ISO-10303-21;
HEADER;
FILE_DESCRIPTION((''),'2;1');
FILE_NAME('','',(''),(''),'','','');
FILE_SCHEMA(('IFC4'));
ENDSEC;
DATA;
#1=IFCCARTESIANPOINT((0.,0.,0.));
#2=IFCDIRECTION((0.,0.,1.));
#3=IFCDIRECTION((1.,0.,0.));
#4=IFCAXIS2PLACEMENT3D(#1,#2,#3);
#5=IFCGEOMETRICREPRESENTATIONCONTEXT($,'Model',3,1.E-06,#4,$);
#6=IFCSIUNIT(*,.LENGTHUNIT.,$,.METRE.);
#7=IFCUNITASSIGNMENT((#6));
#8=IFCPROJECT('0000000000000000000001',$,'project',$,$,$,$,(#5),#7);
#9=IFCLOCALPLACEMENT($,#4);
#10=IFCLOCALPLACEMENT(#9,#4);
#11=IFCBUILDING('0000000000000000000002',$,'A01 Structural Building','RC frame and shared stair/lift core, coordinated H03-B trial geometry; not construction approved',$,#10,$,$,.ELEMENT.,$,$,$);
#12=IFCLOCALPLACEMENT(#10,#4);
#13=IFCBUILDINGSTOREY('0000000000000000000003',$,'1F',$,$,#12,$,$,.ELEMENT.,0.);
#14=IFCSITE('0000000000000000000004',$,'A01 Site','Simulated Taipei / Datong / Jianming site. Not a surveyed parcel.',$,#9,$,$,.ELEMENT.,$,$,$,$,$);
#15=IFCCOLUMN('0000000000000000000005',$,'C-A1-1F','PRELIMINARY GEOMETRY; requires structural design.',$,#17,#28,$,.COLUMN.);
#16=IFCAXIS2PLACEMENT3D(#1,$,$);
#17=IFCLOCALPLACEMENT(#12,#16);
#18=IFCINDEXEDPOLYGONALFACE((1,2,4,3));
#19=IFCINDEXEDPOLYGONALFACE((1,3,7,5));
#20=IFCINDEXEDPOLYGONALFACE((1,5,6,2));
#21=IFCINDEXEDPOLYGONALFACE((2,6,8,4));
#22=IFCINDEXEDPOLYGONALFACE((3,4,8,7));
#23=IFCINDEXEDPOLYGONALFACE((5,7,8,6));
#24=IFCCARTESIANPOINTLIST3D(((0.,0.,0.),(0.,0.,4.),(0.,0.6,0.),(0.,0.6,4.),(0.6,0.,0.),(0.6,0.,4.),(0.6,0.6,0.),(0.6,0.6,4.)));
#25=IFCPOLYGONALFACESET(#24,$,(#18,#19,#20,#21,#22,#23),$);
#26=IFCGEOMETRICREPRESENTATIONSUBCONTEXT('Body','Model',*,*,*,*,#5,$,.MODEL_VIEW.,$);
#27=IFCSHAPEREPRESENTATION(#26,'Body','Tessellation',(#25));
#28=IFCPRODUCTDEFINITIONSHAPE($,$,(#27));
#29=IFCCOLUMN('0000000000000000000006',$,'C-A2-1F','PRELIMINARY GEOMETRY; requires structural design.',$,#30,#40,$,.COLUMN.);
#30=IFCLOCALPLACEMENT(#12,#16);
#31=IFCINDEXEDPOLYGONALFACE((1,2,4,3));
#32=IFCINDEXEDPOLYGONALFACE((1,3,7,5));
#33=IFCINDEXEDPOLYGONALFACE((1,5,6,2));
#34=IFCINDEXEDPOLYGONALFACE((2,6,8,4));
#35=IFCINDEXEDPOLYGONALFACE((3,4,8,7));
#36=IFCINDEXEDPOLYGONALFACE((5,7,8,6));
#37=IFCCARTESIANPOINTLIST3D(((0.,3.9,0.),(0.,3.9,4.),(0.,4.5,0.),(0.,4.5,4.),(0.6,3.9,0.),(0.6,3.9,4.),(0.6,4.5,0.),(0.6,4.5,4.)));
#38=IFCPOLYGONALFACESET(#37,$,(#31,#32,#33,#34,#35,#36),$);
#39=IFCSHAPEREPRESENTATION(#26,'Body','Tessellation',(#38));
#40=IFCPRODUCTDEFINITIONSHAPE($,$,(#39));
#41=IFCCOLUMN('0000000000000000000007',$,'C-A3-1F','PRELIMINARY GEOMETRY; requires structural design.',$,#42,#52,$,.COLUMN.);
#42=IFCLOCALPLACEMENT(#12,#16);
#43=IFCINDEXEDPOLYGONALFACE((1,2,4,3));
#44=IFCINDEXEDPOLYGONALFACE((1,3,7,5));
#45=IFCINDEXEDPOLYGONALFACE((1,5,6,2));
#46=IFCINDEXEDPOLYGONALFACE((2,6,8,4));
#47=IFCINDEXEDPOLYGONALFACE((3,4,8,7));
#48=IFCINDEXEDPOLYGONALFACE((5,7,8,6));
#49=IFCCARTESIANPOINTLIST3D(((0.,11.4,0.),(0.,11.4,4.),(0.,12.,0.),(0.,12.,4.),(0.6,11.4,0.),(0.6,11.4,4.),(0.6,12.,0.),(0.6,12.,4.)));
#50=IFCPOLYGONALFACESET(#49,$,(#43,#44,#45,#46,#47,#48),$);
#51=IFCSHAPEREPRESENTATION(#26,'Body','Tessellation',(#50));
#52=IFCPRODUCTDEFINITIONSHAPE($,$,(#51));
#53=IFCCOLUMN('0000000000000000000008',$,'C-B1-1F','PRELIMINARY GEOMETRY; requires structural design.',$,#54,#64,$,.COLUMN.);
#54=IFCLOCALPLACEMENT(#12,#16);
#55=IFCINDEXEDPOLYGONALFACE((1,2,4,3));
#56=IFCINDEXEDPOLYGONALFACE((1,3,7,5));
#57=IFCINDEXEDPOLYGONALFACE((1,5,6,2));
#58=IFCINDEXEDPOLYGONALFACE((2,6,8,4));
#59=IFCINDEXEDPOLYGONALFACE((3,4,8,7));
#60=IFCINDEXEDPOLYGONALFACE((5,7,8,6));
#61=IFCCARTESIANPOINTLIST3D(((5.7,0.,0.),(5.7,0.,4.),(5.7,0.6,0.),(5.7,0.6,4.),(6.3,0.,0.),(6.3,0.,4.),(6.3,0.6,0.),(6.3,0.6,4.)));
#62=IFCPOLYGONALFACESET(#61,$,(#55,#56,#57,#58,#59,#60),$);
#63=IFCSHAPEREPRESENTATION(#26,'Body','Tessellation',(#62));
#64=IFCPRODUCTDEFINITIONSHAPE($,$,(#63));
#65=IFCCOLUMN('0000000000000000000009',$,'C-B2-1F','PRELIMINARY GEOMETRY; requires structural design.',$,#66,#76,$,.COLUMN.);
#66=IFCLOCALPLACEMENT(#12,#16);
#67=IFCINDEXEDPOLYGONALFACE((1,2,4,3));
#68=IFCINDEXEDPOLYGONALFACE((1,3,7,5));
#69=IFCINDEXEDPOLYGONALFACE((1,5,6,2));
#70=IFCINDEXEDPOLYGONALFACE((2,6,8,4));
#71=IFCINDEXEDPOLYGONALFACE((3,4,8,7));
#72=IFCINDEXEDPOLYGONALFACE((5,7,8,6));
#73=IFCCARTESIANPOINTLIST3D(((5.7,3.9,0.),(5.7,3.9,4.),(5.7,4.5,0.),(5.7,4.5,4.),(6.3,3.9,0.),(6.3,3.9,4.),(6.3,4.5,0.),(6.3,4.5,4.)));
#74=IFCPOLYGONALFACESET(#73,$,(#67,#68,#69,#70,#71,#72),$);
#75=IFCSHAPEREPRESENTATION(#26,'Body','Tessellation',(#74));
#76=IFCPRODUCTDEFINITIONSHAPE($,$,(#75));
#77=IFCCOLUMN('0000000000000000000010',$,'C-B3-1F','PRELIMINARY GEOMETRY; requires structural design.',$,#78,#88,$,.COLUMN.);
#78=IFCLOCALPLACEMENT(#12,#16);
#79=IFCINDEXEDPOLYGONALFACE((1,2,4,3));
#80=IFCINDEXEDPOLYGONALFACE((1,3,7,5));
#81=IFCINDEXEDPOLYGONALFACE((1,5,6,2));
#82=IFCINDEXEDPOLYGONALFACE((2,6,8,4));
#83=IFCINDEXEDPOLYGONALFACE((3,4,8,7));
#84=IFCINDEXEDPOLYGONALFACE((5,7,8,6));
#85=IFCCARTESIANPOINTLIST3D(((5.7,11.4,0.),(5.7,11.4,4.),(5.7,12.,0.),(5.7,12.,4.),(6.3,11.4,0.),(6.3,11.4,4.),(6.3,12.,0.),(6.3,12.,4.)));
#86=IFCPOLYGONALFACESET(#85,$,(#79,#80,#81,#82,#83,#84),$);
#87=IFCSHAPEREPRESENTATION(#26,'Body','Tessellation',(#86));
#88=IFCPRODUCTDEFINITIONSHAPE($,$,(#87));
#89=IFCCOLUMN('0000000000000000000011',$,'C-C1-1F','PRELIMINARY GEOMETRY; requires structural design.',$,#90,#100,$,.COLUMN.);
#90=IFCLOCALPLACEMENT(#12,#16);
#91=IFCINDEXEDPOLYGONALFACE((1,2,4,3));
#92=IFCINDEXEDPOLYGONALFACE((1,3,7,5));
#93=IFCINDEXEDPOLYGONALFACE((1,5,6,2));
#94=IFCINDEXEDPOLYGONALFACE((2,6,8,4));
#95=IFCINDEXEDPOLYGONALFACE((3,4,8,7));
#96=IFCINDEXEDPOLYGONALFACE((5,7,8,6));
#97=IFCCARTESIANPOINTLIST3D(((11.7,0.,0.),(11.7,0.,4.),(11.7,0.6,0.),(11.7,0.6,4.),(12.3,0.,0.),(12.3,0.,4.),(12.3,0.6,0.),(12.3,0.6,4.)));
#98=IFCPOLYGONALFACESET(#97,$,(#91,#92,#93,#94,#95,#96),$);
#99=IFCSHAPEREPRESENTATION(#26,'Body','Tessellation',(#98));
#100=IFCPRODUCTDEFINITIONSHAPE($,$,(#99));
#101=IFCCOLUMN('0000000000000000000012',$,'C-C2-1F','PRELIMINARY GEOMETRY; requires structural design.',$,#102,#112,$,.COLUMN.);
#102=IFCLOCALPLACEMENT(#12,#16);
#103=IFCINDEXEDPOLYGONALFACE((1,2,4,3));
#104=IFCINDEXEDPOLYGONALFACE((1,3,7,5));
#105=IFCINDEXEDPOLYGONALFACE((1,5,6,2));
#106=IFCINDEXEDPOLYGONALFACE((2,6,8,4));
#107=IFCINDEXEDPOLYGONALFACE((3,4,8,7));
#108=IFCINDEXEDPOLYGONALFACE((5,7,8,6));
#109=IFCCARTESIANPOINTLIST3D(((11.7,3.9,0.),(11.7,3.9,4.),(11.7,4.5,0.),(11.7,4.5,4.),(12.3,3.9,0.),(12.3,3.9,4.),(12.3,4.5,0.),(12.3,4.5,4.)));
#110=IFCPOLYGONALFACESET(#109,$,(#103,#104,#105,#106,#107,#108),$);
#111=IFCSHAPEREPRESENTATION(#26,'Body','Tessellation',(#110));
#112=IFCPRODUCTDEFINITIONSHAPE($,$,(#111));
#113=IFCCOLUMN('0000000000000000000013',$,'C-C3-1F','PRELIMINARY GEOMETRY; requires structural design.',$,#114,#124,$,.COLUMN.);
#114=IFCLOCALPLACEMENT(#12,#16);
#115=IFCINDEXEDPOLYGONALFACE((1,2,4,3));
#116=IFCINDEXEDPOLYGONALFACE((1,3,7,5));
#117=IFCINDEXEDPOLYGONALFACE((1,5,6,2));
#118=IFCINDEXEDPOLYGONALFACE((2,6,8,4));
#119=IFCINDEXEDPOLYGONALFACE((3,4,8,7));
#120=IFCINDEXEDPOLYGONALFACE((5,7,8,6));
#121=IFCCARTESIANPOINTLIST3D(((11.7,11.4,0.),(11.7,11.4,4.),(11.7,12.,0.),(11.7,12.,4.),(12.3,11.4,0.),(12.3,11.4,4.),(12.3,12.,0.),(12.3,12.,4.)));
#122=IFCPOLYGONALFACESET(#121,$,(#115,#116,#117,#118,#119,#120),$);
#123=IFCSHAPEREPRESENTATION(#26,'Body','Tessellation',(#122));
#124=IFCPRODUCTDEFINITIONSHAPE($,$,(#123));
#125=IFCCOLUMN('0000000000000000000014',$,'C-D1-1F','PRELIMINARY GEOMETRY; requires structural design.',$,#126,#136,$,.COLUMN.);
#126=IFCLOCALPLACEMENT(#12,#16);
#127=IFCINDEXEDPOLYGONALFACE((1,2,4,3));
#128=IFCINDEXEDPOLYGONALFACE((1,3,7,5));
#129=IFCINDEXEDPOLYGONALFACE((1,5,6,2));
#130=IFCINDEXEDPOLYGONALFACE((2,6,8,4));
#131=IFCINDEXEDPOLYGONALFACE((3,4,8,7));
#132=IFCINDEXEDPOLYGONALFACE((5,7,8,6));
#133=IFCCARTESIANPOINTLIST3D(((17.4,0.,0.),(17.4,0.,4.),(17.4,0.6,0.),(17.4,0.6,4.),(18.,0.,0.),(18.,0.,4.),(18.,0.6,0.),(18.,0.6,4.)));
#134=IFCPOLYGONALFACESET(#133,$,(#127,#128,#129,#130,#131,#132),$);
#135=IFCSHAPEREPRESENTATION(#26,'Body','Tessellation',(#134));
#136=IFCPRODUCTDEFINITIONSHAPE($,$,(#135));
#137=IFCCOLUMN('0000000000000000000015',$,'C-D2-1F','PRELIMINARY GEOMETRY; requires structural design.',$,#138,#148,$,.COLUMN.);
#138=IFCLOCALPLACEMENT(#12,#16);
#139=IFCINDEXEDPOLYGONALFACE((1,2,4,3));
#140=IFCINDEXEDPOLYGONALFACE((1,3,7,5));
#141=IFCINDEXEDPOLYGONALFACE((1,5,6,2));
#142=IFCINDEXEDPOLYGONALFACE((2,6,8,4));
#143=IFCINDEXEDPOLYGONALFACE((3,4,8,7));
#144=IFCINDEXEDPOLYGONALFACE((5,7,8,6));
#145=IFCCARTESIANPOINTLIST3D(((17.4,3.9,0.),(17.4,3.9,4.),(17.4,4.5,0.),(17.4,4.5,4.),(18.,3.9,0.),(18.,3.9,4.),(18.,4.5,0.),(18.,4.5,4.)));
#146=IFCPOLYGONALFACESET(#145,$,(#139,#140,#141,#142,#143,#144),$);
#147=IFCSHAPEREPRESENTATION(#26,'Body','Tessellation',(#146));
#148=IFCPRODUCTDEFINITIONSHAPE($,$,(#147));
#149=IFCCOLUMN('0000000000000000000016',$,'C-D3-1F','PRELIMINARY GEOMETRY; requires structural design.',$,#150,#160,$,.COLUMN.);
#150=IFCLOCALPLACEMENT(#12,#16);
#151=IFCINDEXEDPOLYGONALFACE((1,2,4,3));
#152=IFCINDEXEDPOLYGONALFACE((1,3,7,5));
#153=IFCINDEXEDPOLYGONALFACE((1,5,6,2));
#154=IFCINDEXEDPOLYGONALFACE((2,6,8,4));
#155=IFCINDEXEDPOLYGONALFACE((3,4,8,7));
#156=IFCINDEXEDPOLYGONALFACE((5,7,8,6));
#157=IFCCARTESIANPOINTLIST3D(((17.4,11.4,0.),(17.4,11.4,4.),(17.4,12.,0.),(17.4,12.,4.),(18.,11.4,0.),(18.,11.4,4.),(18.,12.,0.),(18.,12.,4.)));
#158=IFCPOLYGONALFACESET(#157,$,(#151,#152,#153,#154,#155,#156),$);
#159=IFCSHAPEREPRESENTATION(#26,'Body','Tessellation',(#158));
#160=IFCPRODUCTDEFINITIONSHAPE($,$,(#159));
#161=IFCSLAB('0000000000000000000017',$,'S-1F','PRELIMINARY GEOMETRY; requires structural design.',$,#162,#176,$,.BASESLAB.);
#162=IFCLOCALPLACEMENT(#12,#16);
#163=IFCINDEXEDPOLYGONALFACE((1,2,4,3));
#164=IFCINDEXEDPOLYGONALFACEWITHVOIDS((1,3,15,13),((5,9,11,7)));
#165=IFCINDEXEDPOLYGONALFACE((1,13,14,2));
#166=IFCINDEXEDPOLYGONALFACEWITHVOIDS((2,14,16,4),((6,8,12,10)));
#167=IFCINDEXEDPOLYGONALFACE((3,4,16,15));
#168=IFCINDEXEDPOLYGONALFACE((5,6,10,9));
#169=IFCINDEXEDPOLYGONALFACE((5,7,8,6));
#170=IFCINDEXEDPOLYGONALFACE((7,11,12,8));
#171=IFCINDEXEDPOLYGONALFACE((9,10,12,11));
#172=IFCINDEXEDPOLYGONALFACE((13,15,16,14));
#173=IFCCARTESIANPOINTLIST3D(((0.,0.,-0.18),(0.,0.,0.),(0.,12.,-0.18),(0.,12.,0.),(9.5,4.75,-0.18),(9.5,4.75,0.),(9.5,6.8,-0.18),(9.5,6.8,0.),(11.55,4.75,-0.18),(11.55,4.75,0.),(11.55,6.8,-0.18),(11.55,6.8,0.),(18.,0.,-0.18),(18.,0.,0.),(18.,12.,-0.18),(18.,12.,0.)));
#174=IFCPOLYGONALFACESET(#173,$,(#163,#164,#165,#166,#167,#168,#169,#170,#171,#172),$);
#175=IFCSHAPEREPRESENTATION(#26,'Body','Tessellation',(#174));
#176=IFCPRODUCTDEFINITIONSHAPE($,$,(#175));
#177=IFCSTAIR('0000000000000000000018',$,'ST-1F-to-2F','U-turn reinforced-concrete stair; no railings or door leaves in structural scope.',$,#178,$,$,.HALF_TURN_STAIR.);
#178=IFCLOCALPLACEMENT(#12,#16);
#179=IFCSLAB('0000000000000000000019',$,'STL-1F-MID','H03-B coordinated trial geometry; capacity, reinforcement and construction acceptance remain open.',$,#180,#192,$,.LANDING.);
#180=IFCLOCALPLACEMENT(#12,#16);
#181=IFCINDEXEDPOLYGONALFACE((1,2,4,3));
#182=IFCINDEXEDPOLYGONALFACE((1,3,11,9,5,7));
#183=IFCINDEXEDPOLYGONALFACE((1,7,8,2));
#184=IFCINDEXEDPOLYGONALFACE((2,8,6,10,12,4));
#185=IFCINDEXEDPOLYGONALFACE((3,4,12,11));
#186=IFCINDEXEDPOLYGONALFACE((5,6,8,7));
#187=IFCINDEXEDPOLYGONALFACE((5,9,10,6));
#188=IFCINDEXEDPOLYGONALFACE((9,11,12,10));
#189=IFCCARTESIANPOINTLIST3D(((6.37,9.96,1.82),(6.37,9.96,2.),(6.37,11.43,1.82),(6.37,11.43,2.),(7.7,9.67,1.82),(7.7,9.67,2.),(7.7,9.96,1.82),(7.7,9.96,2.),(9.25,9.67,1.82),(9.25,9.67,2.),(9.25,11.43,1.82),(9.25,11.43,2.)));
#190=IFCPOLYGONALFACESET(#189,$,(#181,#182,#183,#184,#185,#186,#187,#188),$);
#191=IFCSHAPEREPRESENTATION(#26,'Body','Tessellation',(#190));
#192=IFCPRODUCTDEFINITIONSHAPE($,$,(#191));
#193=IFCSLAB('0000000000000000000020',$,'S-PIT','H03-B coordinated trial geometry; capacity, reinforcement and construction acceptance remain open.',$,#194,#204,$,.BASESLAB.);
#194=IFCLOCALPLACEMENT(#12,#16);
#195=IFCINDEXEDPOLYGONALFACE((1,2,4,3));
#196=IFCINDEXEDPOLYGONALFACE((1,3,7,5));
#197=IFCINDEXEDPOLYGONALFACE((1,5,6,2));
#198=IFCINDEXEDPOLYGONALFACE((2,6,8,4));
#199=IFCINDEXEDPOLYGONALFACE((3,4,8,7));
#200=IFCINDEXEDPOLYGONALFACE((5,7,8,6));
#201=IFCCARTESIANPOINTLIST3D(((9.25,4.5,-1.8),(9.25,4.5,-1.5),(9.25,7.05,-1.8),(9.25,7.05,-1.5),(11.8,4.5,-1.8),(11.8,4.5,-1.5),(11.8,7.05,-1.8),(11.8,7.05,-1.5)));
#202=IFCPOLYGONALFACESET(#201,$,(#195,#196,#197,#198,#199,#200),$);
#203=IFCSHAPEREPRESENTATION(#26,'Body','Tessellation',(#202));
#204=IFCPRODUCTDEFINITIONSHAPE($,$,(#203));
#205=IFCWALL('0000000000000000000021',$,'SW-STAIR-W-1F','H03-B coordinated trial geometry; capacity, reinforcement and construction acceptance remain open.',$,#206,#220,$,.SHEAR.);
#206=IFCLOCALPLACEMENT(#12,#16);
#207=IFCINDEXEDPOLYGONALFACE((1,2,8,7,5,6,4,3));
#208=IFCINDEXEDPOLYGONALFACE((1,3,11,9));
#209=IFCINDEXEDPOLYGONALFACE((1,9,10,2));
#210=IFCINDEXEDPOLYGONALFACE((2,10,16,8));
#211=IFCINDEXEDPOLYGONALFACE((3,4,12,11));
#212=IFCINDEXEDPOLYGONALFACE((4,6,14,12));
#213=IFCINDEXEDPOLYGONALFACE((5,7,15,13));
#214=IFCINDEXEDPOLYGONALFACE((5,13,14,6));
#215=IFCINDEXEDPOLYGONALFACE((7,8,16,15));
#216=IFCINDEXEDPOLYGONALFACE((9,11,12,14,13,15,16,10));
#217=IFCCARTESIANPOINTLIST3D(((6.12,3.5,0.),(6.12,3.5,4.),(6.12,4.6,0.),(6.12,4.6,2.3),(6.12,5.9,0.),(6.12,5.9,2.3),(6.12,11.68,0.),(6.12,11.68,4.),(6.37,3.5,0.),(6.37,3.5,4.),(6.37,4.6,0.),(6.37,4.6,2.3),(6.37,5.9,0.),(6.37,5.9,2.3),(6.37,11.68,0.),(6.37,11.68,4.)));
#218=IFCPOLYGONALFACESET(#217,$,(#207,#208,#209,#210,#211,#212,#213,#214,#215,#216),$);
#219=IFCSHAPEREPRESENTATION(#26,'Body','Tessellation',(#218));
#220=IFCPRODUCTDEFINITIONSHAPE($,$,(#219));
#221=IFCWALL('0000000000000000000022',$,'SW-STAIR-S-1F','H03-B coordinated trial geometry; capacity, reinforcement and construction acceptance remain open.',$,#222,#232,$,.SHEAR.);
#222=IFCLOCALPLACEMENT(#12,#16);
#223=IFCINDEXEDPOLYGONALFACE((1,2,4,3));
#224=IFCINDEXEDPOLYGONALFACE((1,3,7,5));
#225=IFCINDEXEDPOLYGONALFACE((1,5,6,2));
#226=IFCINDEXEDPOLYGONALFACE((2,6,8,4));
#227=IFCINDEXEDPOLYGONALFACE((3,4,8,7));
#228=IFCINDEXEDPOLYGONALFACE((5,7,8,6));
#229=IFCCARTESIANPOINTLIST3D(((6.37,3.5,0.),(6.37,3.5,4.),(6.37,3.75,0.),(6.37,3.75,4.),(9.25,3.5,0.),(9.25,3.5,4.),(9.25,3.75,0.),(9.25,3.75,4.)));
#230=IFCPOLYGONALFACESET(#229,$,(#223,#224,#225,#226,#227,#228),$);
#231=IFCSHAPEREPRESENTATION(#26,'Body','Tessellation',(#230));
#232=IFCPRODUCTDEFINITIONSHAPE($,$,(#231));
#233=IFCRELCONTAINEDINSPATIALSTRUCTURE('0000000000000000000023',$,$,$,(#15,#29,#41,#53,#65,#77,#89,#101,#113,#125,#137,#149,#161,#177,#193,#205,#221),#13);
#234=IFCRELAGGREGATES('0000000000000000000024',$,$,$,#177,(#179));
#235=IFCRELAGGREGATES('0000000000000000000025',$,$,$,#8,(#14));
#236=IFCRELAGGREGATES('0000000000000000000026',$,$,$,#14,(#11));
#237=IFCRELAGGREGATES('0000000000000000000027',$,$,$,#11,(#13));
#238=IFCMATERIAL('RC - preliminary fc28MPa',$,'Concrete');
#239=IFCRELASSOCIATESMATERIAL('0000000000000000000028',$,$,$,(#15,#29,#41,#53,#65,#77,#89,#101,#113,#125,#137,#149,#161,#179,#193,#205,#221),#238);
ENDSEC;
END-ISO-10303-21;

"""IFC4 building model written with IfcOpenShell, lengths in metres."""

from ifc_helpers import new_model, si_unit, frame, origin_with_axes, place, context, subcontext, project, spatial, polyline, rectangle, outline, extrude, material, element, aggregate, save


model = new_model("IFC4")

# Units and contexts
model_context = context("Model", 3, precision=1e-06, world=origin_with_axes())
body_context = subcontext(model_context, "Body", "Model", "MODEL_VIEW")
ifc_project = project(units=[si_unit("LENGTHUNIT", "METRE")], contexts=[model_context])

# Site, building, storey
site_placement = place(None, origin_with_axes())
site = spatial("IfcSite", under=ifc_project, at=site_placement, Name="A01 Site", Description="Simulated Taipei / Datong / Jianming site. Not a surveyed parcel.", CompositionType="ELEMENT")
building_placement = place(site_placement, origin_with_axes())
building = spatial("IfcBuilding", under=site, at=building_placement, Name="A01 Structural Building", Description="RC frame and shared stair/lift core, coordinated H03-B trial geometry; not construction approved", CompositionType="ELEMENT")
storey_placement = place(building_placement, origin_with_axes())
storey = spatial("IfcBuildingStorey", under=building, at=storey_placement, Name="1F", CompositionType="ELEMENT", Elevation=0.0)

# Columns
ifc_material = material(Name="RC - preliminary fc28MPa", Category="Concrete")
for number, where, z_axis, x_axis, name in (
    (1, (0.3, 0.3, 0.0), (0.0, 0.0, 1.0), (1.0, 0.0, 0.0), "C-A1-1F"),
    (2, (0.3, 4.2, 0.0), (0.0, 0.0, 1.0), (1.0, 0.0, 0.0), "C-A2-1F"),
    (3, (0.3, 11.7, 0.0), (0.0, 0.0, 1.0), (1.0, 0.0, 0.0), "C-A3-1F"),
    (4, (6.0, 0.3, 0.0), (0.0, 0.0, 1.0), (1.0, 0.0, 0.0), "C-B1-1F"),
    (5, (6.0, 4.2, 0.0), (0.0, 0.0, 1.0), (1.0, 0.0, 0.0), "C-B2-1F"),
    (6, (6.0, 11.7, 0.0), (0.0, 0.0, 1.0), (1.0, 0.0, 0.0), "C-B3-1F"),
    (7, (12.0, 0.3, 0.0), (0.0, 0.0, 1.0), (1.0, 0.0, 0.0), "C-C1-1F"),
    (8, (12.0, 4.2, 0.0), (0.0, 0.0, 1.0), (1.0, 0.0, 0.0), "C-C2-1F"),
    (9, (12.0, 11.7, 0.0), (0.0, 0.0, 1.0), (1.0, 0.0, 0.0), "C-C3-1F"),
    (10, (17.7, 0.3, 0.0), (0.0, 0.0, 1.0), (1.0, 0.0, 0.0), "C-D1-1F"),
    (11, (17.7, 4.2, 0.0), (0.0, 0.0, 1.0), (1.0, 0.0, 0.0), "C-D2-1F"),
    (12, (17.7, 11.7, 0.0), (0.0, 0.0, 1.0), (1.0, 0.0, 0.0), "C-D3-1F"),
):
    element("IfcColumn", number, at=place(storey_placement, frame(where, z_axis=z_axis, x_axis=x_axis)), inside=storey, material=ifc_material, Name=name, Description="PRELIMINARY GEOMETRY; requires structural design.", PredefinedType="COLUMN", context=body_context, shape_type="SweptSolid", body=[
        extrude(rectangle(XDim=0.6, YDim=0.6), origin_with_axes(), (0.0, 0.0, 1.0), 4.0),
    ])

# Slab, opening
slab_1_placement = place(storey_placement, frame((9.0, 6.0, -0.18), z_axis=(0.0, 0.0, 1.0), x_axis=(1.0, 0.0, 0.0)))
slab_1 = element("IfcSlab", 13, at=slab_1_placement, inside=storey, material=ifc_material, Name="S-1F", Description="PRELIMINARY GEOMETRY; requires structural design.", PredefinedType="BASESLAB", context=body_context, shape_type="SweptSolid", body=[
    extrude(rectangle(XDim=18.0, YDim=12.0), origin_with_axes(), (0.0, 0.0, 1.0), 0.18),
])
opening_1_placement = place(storey_placement, frame((10.525, 5.775, -0.23), z_axis=(0.0, 0.0, 1.0), x_axis=(1.0, 0.0, 0.0)))
element("IfcOpeningElement", 14, at=opening_1_placement, cuts=slab_1, PredefinedType="OPENING", context=body_context, shape_type="SweptSolid", body=[
    extrude(rectangle(XDim=2.05, YDim=2.05), origin_with_axes(), (0.0, 0.0, 1.0), 0.28),
])

# Stair, slab
stair_placement = place(storey_placement, origin_with_axes())
stair = element("IfcStair", 15, at=stair_placement, inside=storey, Name="ST-1F-to-2F", Description="U-turn reinforced-concrete stair; no railings or door leaves in structural scope.", PredefinedType="HALF_TURN_STAIR")
placement = place(None, origin_with_axes())
slab_2 = element("IfcSlab", 16, at=placement, material=ifc_material, Name="STL-1F-MID", Description="H03-B coordinated trial geometry; capacity, reinforcement and construction acceptance remain open.", PredefinedType="LANDING", context=body_context, shape_type="SweptSolid", body=[
    extrude(outline(polyline([(6.37, 9.96), (7.7, 9.96), (7.7, 9.67), (9.25, 9.67), (9.25, 11.43), (6.37, 11.43), (6.37, 9.96)])), frame((0.0, 0.0, 1.82), z_axis=(0.0, 0.0, 1.0), x_axis=(1.0, 0.0, 0.0)), (0.0, 0.0, 1.0), 0.18),
])

# Slab
element("IfcSlab", 17, at=placement, inside=storey, material=ifc_material, Name="S-PIT", Description="H03-B coordinated trial geometry; capacity, reinforcement and construction acceptance remain open.", PredefinedType="BASESLAB", context=body_context, shape_type="SweptSolid", body=[
    extrude(outline(polyline([(11.8, 4.5), (11.8, 7.05), (9.25, 7.05), (9.25, 4.5), (11.8, 4.5)])), frame((0.0, 0.0, -1.8), z_axis=(0.0, 0.0, 1.0), x_axis=(1.0, 0.0, 0.0)), (0.0, 0.0, 1.0), 0.3),
])

# Wall, opening
wall_1 = element("IfcWall", 18, at=placement, inside=storey, material=ifc_material, Name="SW-STAIR-W-1F", Description="H03-B coordinated trial geometry; capacity, reinforcement and construction acceptance remain open.", PredefinedType="SHEAR", context=body_context, shape_type="SweptSolid", body=[
    extrude(outline(polyline([(6.37, 3.5), (6.37, 11.68), (6.12, 11.68), (6.12, 3.5), (6.37, 3.5)])), origin_with_axes(), (0.0, 0.0, 1.0), 4.0),
])
element("IfcOpeningElement", 19, at=placement, cuts=wall_1, PredefinedType="OPENING", context=body_context, shape_type="SweptSolid", body=[
    extrude(outline(polyline([(6.42, 4.6), (6.42, 5.9), (6.07, 5.9), (6.07, 4.6), (6.42, 4.6)])), origin_with_axes(), (0.0, 0.0, 1.0), 2.3),
])

# Wall
element("IfcWall", 20, at=placement, inside=storey, material=ifc_material, Name="SW-STAIR-S-1F", Description="H03-B coordinated trial geometry; capacity, reinforcement and construction acceptance remain open.", PredefinedType="SHEAR", context=body_context, shape_type="SweptSolid", body=[
    extrude(outline(polyline([(9.25, 3.5), (9.25, 3.75), (6.37, 3.75), (6.37, 3.5), (9.25, 3.5)])), origin_with_axes(), (0.0, 0.0, 1.0), 4.0),
])

aggregate(stair, [slab_2])

save(model, "model.ifc")
